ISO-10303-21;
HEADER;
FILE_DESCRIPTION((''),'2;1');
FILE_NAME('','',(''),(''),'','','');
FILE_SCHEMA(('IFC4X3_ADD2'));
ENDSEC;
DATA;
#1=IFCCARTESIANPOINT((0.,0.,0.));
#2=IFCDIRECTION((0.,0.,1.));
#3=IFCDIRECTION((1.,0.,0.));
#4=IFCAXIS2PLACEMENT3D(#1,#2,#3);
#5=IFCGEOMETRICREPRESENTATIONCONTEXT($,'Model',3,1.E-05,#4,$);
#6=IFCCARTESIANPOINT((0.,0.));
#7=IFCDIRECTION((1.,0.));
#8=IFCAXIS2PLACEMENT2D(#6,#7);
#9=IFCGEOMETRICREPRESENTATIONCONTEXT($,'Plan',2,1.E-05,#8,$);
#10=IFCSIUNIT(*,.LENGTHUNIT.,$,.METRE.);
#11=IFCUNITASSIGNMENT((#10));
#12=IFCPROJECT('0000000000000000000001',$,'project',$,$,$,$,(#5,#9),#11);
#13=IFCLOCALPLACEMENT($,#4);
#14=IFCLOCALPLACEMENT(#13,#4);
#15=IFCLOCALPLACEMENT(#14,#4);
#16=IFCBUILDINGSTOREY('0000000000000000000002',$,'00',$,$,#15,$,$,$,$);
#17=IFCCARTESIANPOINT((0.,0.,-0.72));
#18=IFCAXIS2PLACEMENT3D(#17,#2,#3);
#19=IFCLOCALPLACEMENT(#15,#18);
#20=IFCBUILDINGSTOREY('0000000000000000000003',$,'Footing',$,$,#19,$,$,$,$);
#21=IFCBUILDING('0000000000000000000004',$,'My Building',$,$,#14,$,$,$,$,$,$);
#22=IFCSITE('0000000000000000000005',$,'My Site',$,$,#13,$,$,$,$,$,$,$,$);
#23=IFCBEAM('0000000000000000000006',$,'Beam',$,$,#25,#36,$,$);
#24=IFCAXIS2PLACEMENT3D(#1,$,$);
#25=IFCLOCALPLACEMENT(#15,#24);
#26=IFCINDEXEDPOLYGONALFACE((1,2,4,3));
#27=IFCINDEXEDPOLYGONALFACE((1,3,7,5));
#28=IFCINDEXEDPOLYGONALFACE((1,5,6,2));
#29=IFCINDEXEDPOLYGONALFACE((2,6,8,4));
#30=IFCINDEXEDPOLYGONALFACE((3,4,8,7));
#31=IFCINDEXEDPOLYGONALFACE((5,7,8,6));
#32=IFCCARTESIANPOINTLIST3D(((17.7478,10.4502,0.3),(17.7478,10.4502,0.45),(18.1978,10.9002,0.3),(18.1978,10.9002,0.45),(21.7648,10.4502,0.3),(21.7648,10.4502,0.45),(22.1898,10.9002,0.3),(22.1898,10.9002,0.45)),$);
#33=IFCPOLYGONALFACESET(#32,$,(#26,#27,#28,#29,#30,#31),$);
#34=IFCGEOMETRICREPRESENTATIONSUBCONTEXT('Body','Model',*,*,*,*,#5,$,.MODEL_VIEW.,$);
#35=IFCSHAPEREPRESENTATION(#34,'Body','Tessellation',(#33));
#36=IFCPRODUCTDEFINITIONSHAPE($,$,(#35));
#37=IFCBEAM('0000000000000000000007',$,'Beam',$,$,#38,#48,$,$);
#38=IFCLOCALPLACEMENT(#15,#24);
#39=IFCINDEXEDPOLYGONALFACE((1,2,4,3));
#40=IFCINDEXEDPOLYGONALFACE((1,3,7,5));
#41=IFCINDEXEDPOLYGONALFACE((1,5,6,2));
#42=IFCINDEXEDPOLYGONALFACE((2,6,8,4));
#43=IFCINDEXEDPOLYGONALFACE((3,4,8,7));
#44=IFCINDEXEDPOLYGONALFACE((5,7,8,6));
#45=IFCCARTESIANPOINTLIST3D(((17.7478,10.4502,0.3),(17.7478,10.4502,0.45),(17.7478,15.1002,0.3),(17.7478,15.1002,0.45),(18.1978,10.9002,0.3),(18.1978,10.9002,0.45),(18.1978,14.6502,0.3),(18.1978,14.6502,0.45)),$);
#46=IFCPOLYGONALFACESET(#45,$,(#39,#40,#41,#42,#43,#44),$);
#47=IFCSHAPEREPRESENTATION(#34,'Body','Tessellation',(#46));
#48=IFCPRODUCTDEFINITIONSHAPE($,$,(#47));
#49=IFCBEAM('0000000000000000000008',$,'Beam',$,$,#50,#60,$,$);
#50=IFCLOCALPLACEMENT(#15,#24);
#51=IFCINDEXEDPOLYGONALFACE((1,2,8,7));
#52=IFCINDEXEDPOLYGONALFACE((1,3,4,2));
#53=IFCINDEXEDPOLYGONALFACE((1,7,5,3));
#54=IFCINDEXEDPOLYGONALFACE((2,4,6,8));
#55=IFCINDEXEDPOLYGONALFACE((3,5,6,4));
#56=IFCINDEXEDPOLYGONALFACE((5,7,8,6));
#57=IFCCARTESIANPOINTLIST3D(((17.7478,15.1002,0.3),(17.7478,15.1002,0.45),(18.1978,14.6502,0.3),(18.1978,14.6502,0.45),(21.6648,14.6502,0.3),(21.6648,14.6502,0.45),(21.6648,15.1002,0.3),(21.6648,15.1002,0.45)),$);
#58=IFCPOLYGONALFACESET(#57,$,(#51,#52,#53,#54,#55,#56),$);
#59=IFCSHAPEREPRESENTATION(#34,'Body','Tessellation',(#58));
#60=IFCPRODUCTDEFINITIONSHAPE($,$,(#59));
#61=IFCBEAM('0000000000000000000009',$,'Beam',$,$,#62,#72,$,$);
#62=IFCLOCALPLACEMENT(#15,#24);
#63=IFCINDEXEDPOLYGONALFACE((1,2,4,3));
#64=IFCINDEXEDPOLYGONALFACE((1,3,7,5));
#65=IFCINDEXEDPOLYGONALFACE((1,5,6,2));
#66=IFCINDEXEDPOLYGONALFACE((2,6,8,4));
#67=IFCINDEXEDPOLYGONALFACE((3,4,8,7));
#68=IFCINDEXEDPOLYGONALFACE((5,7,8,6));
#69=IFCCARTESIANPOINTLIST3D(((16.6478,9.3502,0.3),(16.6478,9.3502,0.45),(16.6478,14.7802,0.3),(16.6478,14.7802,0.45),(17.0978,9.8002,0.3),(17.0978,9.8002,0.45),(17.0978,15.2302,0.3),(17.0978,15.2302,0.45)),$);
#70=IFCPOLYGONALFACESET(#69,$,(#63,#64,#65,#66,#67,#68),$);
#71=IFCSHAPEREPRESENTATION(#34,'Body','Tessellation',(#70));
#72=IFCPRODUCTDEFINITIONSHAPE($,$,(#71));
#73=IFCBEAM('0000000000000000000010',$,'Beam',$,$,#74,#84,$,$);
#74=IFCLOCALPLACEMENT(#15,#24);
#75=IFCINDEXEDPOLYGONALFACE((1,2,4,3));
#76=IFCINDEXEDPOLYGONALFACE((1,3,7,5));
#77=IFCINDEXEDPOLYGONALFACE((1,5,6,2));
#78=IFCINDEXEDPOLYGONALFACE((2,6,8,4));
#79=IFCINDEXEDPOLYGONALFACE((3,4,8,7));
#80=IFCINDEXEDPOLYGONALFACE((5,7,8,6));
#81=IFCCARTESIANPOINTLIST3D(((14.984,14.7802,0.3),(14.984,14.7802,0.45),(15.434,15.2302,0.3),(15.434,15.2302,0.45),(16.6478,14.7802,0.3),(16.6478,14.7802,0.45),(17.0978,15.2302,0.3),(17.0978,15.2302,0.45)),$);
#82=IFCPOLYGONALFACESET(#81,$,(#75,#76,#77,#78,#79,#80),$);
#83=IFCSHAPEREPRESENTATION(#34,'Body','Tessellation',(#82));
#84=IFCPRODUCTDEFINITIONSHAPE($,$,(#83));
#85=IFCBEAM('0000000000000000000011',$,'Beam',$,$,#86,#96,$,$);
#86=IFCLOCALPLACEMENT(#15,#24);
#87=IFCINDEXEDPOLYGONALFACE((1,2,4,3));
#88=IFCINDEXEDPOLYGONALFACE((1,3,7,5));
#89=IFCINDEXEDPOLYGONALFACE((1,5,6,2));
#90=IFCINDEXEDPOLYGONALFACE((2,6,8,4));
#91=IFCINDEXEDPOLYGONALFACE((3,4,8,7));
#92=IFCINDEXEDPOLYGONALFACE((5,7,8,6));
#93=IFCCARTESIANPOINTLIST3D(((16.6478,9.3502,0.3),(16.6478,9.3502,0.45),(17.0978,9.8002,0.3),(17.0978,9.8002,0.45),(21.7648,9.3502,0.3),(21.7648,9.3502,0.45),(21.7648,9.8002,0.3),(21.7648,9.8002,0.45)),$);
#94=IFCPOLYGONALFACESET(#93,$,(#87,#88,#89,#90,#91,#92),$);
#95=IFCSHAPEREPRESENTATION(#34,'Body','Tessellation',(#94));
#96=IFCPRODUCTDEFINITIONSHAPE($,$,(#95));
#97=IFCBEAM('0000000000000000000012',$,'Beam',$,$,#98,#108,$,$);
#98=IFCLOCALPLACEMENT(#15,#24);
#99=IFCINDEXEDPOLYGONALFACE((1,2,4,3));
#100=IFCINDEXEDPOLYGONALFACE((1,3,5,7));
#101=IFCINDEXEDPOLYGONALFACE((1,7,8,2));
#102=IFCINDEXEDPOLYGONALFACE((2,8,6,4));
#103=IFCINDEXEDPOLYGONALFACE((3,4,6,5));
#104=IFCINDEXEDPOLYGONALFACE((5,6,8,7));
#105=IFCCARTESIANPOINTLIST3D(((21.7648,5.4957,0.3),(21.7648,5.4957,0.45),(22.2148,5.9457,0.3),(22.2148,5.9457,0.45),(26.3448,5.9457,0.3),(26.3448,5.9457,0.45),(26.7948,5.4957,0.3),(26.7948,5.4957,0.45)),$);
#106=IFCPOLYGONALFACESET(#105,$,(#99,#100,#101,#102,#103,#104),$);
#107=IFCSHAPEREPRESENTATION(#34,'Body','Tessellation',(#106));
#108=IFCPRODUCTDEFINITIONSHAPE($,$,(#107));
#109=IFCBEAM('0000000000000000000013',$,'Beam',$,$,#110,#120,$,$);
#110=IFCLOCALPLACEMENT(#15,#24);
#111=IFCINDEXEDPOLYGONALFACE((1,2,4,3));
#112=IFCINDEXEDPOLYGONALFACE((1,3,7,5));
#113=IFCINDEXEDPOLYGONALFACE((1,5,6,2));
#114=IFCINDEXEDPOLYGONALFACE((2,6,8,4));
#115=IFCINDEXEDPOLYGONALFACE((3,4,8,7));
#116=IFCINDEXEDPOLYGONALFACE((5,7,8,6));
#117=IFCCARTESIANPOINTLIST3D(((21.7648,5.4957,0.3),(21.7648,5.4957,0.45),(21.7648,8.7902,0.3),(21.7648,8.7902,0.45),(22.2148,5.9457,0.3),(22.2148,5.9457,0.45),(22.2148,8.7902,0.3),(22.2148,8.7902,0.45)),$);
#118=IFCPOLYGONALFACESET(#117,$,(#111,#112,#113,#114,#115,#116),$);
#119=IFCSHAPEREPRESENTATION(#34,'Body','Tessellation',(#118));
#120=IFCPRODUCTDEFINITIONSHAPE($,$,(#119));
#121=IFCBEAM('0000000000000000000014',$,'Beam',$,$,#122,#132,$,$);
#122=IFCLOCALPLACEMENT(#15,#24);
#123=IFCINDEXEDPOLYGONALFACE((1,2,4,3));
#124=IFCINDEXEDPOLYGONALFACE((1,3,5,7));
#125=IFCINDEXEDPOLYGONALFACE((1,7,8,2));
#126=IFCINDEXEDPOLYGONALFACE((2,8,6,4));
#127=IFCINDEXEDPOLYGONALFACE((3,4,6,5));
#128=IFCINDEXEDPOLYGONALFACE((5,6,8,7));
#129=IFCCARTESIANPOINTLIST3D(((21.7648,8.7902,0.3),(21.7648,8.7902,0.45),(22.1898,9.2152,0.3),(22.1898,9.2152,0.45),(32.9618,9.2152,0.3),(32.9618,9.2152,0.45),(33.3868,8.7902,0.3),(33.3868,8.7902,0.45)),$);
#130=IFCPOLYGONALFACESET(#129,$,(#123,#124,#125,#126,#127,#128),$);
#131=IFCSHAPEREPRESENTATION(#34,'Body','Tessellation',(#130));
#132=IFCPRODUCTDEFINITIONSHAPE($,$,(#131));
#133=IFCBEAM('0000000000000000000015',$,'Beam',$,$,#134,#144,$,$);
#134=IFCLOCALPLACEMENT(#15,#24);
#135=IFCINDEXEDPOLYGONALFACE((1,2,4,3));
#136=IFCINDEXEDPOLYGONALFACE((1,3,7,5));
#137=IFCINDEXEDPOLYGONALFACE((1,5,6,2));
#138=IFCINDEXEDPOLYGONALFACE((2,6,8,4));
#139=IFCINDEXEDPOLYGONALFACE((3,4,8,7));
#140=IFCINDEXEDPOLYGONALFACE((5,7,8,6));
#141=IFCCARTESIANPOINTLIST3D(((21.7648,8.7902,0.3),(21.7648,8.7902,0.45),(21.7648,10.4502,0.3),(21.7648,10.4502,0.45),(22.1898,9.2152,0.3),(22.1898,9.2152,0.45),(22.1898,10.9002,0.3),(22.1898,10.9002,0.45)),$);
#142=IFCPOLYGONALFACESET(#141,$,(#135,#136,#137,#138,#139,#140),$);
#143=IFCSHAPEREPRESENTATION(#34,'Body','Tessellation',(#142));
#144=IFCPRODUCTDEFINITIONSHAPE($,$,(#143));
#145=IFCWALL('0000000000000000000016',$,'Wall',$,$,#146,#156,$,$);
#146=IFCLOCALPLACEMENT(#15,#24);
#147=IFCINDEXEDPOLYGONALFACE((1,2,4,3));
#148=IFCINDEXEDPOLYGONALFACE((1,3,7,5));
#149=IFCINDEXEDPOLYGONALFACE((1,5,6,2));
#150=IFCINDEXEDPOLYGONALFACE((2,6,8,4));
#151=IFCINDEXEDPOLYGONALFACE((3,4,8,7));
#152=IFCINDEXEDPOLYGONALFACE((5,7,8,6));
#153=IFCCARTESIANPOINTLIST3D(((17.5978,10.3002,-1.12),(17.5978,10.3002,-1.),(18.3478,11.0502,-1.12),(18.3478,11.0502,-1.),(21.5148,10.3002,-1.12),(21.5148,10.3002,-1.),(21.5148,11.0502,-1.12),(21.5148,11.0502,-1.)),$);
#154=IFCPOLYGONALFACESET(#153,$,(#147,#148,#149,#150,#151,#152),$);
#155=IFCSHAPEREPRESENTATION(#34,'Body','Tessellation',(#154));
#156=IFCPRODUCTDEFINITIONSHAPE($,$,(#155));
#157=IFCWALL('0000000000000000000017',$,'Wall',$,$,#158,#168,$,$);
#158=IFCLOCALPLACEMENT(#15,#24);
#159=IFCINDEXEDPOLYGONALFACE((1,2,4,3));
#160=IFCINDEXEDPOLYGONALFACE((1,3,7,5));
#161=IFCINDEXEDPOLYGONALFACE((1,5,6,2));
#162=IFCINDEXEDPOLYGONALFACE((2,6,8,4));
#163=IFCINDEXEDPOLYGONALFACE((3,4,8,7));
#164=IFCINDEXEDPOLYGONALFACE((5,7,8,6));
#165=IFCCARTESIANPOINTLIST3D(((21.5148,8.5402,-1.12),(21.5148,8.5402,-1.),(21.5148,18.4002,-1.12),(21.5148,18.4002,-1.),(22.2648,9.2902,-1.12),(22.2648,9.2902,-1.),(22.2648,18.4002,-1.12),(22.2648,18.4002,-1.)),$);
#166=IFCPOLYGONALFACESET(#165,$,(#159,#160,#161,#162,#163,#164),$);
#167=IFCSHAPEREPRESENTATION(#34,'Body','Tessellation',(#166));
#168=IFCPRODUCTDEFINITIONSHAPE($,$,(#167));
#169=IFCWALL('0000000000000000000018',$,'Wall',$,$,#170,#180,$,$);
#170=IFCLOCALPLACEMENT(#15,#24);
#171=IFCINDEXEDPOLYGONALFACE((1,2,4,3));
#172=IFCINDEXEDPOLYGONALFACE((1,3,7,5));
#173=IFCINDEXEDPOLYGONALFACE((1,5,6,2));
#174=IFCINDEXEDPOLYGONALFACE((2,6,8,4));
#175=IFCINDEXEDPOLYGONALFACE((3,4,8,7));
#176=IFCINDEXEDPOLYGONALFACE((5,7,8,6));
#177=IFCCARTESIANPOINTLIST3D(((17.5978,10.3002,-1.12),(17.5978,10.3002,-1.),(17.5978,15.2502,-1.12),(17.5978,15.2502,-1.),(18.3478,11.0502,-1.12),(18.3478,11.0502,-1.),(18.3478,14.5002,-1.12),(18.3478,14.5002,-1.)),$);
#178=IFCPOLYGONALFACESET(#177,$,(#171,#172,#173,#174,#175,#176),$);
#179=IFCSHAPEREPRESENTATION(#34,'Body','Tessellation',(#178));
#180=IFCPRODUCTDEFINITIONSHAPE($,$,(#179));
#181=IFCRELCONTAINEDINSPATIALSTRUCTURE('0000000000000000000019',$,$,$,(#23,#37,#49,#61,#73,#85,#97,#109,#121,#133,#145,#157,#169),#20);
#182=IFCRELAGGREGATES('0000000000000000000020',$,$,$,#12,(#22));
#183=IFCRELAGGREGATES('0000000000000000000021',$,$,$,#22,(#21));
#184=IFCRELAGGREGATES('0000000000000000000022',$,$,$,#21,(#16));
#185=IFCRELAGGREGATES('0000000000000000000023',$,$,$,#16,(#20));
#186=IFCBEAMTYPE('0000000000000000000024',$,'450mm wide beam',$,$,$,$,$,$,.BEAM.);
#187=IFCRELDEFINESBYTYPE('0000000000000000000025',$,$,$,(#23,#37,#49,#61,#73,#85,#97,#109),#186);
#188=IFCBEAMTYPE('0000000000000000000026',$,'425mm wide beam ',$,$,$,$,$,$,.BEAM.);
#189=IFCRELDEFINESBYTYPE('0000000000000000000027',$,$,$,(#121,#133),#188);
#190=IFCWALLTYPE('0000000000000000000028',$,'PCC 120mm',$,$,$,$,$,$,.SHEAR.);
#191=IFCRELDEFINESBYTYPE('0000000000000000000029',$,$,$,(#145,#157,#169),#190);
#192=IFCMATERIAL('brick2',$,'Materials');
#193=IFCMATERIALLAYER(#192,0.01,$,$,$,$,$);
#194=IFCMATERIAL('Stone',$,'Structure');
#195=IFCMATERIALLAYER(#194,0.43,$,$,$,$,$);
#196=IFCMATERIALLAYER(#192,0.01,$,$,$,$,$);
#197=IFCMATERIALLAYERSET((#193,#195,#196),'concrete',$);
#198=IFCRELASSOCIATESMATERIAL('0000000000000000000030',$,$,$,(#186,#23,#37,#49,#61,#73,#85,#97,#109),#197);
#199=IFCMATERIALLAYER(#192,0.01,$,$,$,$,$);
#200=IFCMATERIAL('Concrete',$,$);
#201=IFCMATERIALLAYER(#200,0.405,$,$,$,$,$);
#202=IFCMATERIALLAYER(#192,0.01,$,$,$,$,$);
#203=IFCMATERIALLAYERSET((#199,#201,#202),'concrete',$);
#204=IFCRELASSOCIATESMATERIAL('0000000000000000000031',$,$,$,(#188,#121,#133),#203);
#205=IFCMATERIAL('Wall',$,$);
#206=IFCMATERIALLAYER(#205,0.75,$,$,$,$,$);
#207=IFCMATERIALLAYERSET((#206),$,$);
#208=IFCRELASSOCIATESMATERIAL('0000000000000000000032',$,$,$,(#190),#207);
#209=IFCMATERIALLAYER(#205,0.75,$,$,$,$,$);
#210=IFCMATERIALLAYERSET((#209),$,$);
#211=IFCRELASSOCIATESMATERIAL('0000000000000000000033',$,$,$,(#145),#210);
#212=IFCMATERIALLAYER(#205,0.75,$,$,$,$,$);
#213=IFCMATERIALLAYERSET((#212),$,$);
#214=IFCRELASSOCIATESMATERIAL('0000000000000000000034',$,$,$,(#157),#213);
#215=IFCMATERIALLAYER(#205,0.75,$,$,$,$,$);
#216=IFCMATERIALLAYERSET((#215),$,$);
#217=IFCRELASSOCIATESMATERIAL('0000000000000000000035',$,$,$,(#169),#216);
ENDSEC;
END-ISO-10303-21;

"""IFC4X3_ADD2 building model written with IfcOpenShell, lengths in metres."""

from ifc_helpers import new_model, si_unit, frame, origin_with_axes, origin_2d_with_axis, place, context, subcontext, project, spatial, line, indexed_curve, outline, extrude, material, layer, layer_set, layer_usage, type_object, element, save


model = new_model("IFC4X3_ADD2")

# Units and contexts
model_context = context("Model", 3, precision=1e-05, world=origin_with_axes())
plan_context = context("Plan", 2, precision=1e-05, world=origin_2d_with_axis())
body_context = subcontext(model_context, "Body", "Model", "MODEL_VIEW")
ifc_project = project(units=[si_unit("LENGTHUNIT", "METRE")], contexts=[model_context, plan_context])

# Site, building, storeys
site_placement = place(None, origin_with_axes())
site = spatial("IfcSite", under=ifc_project, at=site_placement, Name="My Site")
building_placement = place(site_placement, origin_with_axes())
building = spatial("IfcBuilding", under=site, at=building_placement, Name="My Building")
storey_1_placement = place(building_placement, origin_with_axes())
storey_1 = spatial("IfcBuildingStorey", under=building, at=storey_1_placement, Name="00")
storey_2_placement = place(storey_1_placement, frame((0.0, 0.0, -0.72), z_axis=(0.0, 0.0, 1.0), x_axis=(1.0, 0.0, 0.0)))
storey_2 = spatial("IfcBuildingStorey", under=storey_1, at=storey_2_placement, Name="Footing")

# Beams
ifc_material_1 = material(Name="brick2", Category="Materials")
ifc_layer_1 = layer(ifc_material_1, 0.01)
ifc_material_2 = material(Name="Stone", Category="Structure")
ifc_layer_2 = layer(ifc_material_2, 0.43)
ifc_layer_3 = layer(ifc_material_1, 0.01)
ifc_layer_set_1 = layer_set([ifc_layer_1, ifc_layer_2, ifc_layer_3], Name="concrete")
ifc_layer_usage_1 = layer_usage(ifc_layer_set_1, "AXIS2", "POSITIVE", 0.0)
beam_type_1 = type_object("IfcBeamType", Name="450mm wide beam", PredefinedType="BEAM", material=ifc_layer_set_1)
beam_1_placement = place(storey_2_placement, frame((18.1978, 10.4502, 1.02), z_axis=(0.0, 0.0, 1.0), x_axis=(1.0, 0.0, 0.0)))
element("IfcBeam", 1, at=beam_1_placement, inside=storey_2, type_object=beam_type_1, material=ifc_layer_usage_1, Name="Beam", context=body_context, shape_type="SweptSolid", body=[
    extrude(outline(indexed_curve([(-0.45, 0.0), (0.0, 0.45), (3.992, 0.45), (3.567, 0.0)], segments=[line(1, 2, 3, 4, 1)])), origin_with_axes(), (0.0, 0.0, 1.0), 0.15),
])
ifc_layer_usage_2 = layer_usage(ifc_layer_set_1, "AXIS2", "NEGATIVE", 0.0)
beam_2_placement = place(storey_2_placement, frame((18.1978, 15.1002, 1.02), z_axis=(0.0, 0.0, 1.0), x_axis=(0.0, -1.0, 0.0)))
element("IfcBeam", 2, at=beam_2_placement, inside=storey_2, type_object=beam_type_1, material=ifc_layer_usage_2, Name="Beam", context=body_context, shape_type="SweptSolid", body=[
    extrude(outline(indexed_curve([(0.0, -0.45), (0.45, 0.0), (4.2, 0.0), (4.65, -0.45)], segments=[line(1, 2, 3, 4, 1)])), origin_with_axes(), (0.0, 0.0, 1.0), 0.15),
])
ifc_layer_usage_3 = layer_usage(ifc_layer_set_1, "AXIS2", "NEGATIVE", 0.0)
beam_3_placement = place(storey_2_placement, frame((18.1978, 15.1002, 1.02), z_axis=(0.0, 0.0, 1.0), x_axis=(1.0, 0.0, 0.0)))
element("IfcBeam", 3, at=beam_3_placement, inside=storey_2, type_object=beam_type_1, material=ifc_layer_usage_3, Name="Beam", context=body_context, shape_type="SweptSolid", body=[
    extrude(outline(indexed_curve([(0.0, -0.45), (-0.45, 0.0), (3.467, 0.0), (3.467, -0.45)], segments=[line(1, 2, 3, 4, 1)])), origin_with_axes(), (0.0, 0.0, 1.0), 0.15),
])
ifc_layer_usage_4 = layer_usage(ifc_layer_set_1, "AXIS2", "POSITIVE", 0.0)
beam_4_placement = place(storey_2_placement, frame((16.6478, 15.2302, 1.02), z_axis=(0.0, 0.0, 1.0), x_axis=(0.0, -1.0, 0.0)))
element("IfcBeam", 4, at=beam_4_placement, inside=storey_2, type_object=beam_type_1, material=ifc_layer_usage_4, Name="Beam", context=body_context, shape_type="SweptSolid", body=[
    extrude(outline(indexed_curve([(0.45, 0.0), (0.0, 0.45), (5.43, 0.45), (5.88, 0.0)], segments=[line(1, 2, 3, 4, 1)])), origin_with_axes(), (0.0, 0.0, 1.0), 0.15),
])
ifc_layer_usage_5 = layer_usage(ifc_layer_set_1, "AXIS2", "NEGATIVE", 0.0)
beam_5_placement = place(storey_2_placement, frame((14.984, 15.2302, 1.02), z_axis=(0.0, 0.0, 1.0), x_axis=(1.0, 0.0, 0.0)))
element("IfcBeam", 5, at=beam_5_placement, inside=storey_2, type_object=beam_type_1, material=ifc_layer_usage_5, Name="Beam", context=body_context, shape_type="SweptSolid", body=[
    extrude(outline(indexed_curve([(0.0, -0.45), (0.45, 0.0), (2.1138, 0.0), (1.6638, -0.45)], segments=[line(1, 2, 3, 4, 1)])), origin_with_axes(), (0.0, 0.0, 1.0), 0.15),
])
ifc_layer_usage_6 = layer_usage(ifc_layer_set_1, "AXIS2", "NEGATIVE", 0.0)
beam_6_placement = place(storey_2_placement, frame((16.6478, 9.8002, 1.02), z_axis=(0.0, 0.0, 1.0), x_axis=(1.0, 0.0, 0.0)))
element("IfcBeam", 6, at=beam_6_placement, inside=storey_2, type_object=beam_type_1, material=ifc_layer_usage_6, Name="Beam", context=body_context, shape_type="SweptSolid", body=[
    extrude(outline(indexed_curve([(0.0, -0.45), (0.45, 0.0), (5.117, 0.0), (5.117, -0.45)], segments=[line(1, 2, 3, 4, 1)])), origin_with_axes(), (0.0, 0.0, 1.0), 0.15),
])
ifc_layer_usage_7 = layer_usage(ifc_layer_set_1, "AXIS2", "NEGATIVE", 0.0)
beam_7_placement = place(storey_2_placement, frame((21.7648, 5.9457, 1.02), z_axis=(0.0, 0.0, 1.0), x_axis=(1.0, 0.0, 0.0)))
element("IfcBeam", 7, at=beam_7_placement, inside=storey_2, type_object=beam_type_1, material=ifc_layer_usage_7, Name="Beam", context=body_context, shape_type="SweptSolid", body=[
    extrude(outline(indexed_curve([(0.0, -0.45), (0.45, 0.0), (4.58, 0.0), (5.03, -0.45)], segments=[line(1, 2, 3, 4, 1)])), origin_with_axes(), (0.0, 0.0, 1.0), 0.15),
])
ifc_layer_usage_8 = layer_usage(ifc_layer_set_1, "AXIS2", "POSITIVE", 0.0)
beam_8_placement = place(storey_2_placement, frame((21.7648, 8.7902, 1.02), z_axis=(0.0, 0.0, 1.0), x_axis=(0.0, -1.0, 0.0)))
element("IfcBeam", 8, at=beam_8_placement, inside=storey_2, type_object=beam_type_1, material=ifc_layer_usage_8, Name="Beam", context=body_context, shape_type="SweptSolid", body=[
    extrude(outline(indexed_curve([(0.0, 0.0), (0.0, 0.45), (2.8445, 0.45), (3.2945, 0.0)], segments=[line(1, 2, 3, 4, 1)])), origin_with_axes(), (0.0, 0.0, 1.0), 0.15),
])
ifc_layer_4 = layer(ifc_material_1, 0.01)
ifc_material_3 = material(Name="Concrete")
ifc_layer_5 = layer(ifc_material_3, 0.405)
ifc_layer_6 = layer(ifc_material_1, 0.01)
ifc_layer_set_2 = layer_set([ifc_layer_4, ifc_layer_5, ifc_layer_6], Name="concrete")
ifc_layer_usage_9 = layer_usage(ifc_layer_set_2, "AXIS2", "POSITIVE", 0.0)
beam_type_2 = type_object("IfcBeamType", Name="425mm wide beam ", PredefinedType="BEAM", material=ifc_layer_set_2)
beam_9_placement = place(storey_2_placement, frame((22.1898, 8.7902, 1.02), z_axis=(0.0, 0.0, 1.0), x_axis=(1.0, 0.0, 0.0)))
element("IfcBeam", 9, at=beam_9_placement, inside=storey_2, type_object=beam_type_2, material=ifc_layer_usage_9, Name="Beam", context=body_context, shape_type="SweptSolid", body=[
    extrude(outline(indexed_curve([(-0.425, 0.0), (0.0, 0.425), (10.772, 0.425), (11.197, 0.0)], segments=[line(1, 2, 3, 4, 1)])), origin_with_axes(), (0.0, 0.0, 1.0), 0.15),
])
ifc_layer_usage_10 = layer_usage(ifc_layer_set_2, "AXIS2", "NEGATIVE", 0.0)
beam_10_placement = place(storey_2_placement, frame((22.1898, 10.4502, 1.02), z_axis=(0.0, 0.0, 1.0), x_axis=(0.0, -1.0, 0.0)))
element("IfcBeam", 10, at=beam_10_placement, inside=storey_2, type_object=beam_type_2, material=ifc_layer_usage_10, Name="Beam", context=body_context, shape_type="SweptSolid", body=[
    extrude(outline(indexed_curve([(0.0, -0.425), (-0.45, 0.0), (1.235, 0.0), (1.66, -0.425)], segments=[line(1, 2, 3, 4, 1)])), origin_with_axes(), (0.0, 0.0, 1.0), 0.15),
])

# Walls
ifc_material_4 = material(Name="Wall")
ifc_layer_7 = layer(ifc_material_4, 0.75)
ifc_layer_set_3 = layer_set([ifc_layer_7])
ifc_layer_usage_11 = layer_usage(ifc_layer_set_3, "AXIS2", "POSITIVE", 0.0)
ifc_layer_8 = layer(ifc_material_4, 0.75)
ifc_layer_set_4 = layer_set([ifc_layer_8])
wall_type_1 = type_object("IfcWallType", Name="PCC 120mm", PredefinedType="SHEAR", material=ifc_layer_set_4)
wall_1_placement = place(storey_2_placement, frame((18.3478, 10.3002, -0.4), z_axis=(0.0, 0.0, 1.0), x_axis=(1.0, 0.0, 0.0)))
element("IfcWall", 11, at=wall_1_placement, inside=storey_2, type_object=wall_type_1, material=ifc_layer_usage_11, Name="Wall", context=body_context, shape_type="SweptSolid", body=[
    extrude(outline(indexed_curve([(-0.75, 0.0), (0.0, 0.75), (3.167, 0.75), (3.167, 0.0)], segments=[line(1, 2, 3, 4, 1)])), origin_with_axes(), (0.0, 0.0, 1.0), 0.12),
])
ifc_layer_9 = layer(ifc_material_4, 0.75)
ifc_layer_set_5 = layer_set([ifc_layer_9])
ifc_layer_usage_12 = layer_usage(ifc_layer_set_5, "AXIS2", "POSITIVE", 0.0)
wall_2_placement = place(storey_2_placement, frame((22.2648, 8.5402, -0.4), z_axis=(0.0, 0.0, 1.0), x_axis=(0.0, 1.0, 0.0)))
element("IfcWall", 12, at=wall_2_placement, inside=storey_2, type_object=wall_type_1, material=ifc_layer_usage_12, Name="Wall", context=body_context, shape_type="SweptSolid", body=[
    extrude(outline(indexed_curve([(0.75, 0.0), (0.0, 0.75), (9.86, 0.75), (9.86, 0.0)], segments=[line(1, 2, 3, 4, 1)])), origin_with_axes(), (0.0, 0.0, 1.0), 0.12),
])
ifc_layer_10 = layer(ifc_material_4, 0.75)
ifc_layer_set_6 = layer_set([ifc_layer_10])
ifc_layer_usage_13 = layer_usage(ifc_layer_set_6, "AXIS2", "POSITIVE", 0.0)
wall_3_placement = place(storey_2_placement, frame((18.3478, 10.3002, -0.4), z_axis=(0.0, 0.0, 1.0), x_axis=(0.0, 1.0, 0.0)))
element("IfcWall", 13, at=wall_3_placement, inside=storey_2, type_object=wall_type_1, material=ifc_layer_usage_13, Name="Wall", context=body_context, shape_type="SweptSolid", body=[
    extrude(outline(indexed_curve([(0.75, 0.0), (0.0, 0.75), (4.95, 0.75), (4.2, 0.0)], segments=[line(1, 2, 3, 4, 1)])), origin_with_axes(), (0.0, 0.0, 1.0), 0.12),
])

save(model, "model.ifc")
